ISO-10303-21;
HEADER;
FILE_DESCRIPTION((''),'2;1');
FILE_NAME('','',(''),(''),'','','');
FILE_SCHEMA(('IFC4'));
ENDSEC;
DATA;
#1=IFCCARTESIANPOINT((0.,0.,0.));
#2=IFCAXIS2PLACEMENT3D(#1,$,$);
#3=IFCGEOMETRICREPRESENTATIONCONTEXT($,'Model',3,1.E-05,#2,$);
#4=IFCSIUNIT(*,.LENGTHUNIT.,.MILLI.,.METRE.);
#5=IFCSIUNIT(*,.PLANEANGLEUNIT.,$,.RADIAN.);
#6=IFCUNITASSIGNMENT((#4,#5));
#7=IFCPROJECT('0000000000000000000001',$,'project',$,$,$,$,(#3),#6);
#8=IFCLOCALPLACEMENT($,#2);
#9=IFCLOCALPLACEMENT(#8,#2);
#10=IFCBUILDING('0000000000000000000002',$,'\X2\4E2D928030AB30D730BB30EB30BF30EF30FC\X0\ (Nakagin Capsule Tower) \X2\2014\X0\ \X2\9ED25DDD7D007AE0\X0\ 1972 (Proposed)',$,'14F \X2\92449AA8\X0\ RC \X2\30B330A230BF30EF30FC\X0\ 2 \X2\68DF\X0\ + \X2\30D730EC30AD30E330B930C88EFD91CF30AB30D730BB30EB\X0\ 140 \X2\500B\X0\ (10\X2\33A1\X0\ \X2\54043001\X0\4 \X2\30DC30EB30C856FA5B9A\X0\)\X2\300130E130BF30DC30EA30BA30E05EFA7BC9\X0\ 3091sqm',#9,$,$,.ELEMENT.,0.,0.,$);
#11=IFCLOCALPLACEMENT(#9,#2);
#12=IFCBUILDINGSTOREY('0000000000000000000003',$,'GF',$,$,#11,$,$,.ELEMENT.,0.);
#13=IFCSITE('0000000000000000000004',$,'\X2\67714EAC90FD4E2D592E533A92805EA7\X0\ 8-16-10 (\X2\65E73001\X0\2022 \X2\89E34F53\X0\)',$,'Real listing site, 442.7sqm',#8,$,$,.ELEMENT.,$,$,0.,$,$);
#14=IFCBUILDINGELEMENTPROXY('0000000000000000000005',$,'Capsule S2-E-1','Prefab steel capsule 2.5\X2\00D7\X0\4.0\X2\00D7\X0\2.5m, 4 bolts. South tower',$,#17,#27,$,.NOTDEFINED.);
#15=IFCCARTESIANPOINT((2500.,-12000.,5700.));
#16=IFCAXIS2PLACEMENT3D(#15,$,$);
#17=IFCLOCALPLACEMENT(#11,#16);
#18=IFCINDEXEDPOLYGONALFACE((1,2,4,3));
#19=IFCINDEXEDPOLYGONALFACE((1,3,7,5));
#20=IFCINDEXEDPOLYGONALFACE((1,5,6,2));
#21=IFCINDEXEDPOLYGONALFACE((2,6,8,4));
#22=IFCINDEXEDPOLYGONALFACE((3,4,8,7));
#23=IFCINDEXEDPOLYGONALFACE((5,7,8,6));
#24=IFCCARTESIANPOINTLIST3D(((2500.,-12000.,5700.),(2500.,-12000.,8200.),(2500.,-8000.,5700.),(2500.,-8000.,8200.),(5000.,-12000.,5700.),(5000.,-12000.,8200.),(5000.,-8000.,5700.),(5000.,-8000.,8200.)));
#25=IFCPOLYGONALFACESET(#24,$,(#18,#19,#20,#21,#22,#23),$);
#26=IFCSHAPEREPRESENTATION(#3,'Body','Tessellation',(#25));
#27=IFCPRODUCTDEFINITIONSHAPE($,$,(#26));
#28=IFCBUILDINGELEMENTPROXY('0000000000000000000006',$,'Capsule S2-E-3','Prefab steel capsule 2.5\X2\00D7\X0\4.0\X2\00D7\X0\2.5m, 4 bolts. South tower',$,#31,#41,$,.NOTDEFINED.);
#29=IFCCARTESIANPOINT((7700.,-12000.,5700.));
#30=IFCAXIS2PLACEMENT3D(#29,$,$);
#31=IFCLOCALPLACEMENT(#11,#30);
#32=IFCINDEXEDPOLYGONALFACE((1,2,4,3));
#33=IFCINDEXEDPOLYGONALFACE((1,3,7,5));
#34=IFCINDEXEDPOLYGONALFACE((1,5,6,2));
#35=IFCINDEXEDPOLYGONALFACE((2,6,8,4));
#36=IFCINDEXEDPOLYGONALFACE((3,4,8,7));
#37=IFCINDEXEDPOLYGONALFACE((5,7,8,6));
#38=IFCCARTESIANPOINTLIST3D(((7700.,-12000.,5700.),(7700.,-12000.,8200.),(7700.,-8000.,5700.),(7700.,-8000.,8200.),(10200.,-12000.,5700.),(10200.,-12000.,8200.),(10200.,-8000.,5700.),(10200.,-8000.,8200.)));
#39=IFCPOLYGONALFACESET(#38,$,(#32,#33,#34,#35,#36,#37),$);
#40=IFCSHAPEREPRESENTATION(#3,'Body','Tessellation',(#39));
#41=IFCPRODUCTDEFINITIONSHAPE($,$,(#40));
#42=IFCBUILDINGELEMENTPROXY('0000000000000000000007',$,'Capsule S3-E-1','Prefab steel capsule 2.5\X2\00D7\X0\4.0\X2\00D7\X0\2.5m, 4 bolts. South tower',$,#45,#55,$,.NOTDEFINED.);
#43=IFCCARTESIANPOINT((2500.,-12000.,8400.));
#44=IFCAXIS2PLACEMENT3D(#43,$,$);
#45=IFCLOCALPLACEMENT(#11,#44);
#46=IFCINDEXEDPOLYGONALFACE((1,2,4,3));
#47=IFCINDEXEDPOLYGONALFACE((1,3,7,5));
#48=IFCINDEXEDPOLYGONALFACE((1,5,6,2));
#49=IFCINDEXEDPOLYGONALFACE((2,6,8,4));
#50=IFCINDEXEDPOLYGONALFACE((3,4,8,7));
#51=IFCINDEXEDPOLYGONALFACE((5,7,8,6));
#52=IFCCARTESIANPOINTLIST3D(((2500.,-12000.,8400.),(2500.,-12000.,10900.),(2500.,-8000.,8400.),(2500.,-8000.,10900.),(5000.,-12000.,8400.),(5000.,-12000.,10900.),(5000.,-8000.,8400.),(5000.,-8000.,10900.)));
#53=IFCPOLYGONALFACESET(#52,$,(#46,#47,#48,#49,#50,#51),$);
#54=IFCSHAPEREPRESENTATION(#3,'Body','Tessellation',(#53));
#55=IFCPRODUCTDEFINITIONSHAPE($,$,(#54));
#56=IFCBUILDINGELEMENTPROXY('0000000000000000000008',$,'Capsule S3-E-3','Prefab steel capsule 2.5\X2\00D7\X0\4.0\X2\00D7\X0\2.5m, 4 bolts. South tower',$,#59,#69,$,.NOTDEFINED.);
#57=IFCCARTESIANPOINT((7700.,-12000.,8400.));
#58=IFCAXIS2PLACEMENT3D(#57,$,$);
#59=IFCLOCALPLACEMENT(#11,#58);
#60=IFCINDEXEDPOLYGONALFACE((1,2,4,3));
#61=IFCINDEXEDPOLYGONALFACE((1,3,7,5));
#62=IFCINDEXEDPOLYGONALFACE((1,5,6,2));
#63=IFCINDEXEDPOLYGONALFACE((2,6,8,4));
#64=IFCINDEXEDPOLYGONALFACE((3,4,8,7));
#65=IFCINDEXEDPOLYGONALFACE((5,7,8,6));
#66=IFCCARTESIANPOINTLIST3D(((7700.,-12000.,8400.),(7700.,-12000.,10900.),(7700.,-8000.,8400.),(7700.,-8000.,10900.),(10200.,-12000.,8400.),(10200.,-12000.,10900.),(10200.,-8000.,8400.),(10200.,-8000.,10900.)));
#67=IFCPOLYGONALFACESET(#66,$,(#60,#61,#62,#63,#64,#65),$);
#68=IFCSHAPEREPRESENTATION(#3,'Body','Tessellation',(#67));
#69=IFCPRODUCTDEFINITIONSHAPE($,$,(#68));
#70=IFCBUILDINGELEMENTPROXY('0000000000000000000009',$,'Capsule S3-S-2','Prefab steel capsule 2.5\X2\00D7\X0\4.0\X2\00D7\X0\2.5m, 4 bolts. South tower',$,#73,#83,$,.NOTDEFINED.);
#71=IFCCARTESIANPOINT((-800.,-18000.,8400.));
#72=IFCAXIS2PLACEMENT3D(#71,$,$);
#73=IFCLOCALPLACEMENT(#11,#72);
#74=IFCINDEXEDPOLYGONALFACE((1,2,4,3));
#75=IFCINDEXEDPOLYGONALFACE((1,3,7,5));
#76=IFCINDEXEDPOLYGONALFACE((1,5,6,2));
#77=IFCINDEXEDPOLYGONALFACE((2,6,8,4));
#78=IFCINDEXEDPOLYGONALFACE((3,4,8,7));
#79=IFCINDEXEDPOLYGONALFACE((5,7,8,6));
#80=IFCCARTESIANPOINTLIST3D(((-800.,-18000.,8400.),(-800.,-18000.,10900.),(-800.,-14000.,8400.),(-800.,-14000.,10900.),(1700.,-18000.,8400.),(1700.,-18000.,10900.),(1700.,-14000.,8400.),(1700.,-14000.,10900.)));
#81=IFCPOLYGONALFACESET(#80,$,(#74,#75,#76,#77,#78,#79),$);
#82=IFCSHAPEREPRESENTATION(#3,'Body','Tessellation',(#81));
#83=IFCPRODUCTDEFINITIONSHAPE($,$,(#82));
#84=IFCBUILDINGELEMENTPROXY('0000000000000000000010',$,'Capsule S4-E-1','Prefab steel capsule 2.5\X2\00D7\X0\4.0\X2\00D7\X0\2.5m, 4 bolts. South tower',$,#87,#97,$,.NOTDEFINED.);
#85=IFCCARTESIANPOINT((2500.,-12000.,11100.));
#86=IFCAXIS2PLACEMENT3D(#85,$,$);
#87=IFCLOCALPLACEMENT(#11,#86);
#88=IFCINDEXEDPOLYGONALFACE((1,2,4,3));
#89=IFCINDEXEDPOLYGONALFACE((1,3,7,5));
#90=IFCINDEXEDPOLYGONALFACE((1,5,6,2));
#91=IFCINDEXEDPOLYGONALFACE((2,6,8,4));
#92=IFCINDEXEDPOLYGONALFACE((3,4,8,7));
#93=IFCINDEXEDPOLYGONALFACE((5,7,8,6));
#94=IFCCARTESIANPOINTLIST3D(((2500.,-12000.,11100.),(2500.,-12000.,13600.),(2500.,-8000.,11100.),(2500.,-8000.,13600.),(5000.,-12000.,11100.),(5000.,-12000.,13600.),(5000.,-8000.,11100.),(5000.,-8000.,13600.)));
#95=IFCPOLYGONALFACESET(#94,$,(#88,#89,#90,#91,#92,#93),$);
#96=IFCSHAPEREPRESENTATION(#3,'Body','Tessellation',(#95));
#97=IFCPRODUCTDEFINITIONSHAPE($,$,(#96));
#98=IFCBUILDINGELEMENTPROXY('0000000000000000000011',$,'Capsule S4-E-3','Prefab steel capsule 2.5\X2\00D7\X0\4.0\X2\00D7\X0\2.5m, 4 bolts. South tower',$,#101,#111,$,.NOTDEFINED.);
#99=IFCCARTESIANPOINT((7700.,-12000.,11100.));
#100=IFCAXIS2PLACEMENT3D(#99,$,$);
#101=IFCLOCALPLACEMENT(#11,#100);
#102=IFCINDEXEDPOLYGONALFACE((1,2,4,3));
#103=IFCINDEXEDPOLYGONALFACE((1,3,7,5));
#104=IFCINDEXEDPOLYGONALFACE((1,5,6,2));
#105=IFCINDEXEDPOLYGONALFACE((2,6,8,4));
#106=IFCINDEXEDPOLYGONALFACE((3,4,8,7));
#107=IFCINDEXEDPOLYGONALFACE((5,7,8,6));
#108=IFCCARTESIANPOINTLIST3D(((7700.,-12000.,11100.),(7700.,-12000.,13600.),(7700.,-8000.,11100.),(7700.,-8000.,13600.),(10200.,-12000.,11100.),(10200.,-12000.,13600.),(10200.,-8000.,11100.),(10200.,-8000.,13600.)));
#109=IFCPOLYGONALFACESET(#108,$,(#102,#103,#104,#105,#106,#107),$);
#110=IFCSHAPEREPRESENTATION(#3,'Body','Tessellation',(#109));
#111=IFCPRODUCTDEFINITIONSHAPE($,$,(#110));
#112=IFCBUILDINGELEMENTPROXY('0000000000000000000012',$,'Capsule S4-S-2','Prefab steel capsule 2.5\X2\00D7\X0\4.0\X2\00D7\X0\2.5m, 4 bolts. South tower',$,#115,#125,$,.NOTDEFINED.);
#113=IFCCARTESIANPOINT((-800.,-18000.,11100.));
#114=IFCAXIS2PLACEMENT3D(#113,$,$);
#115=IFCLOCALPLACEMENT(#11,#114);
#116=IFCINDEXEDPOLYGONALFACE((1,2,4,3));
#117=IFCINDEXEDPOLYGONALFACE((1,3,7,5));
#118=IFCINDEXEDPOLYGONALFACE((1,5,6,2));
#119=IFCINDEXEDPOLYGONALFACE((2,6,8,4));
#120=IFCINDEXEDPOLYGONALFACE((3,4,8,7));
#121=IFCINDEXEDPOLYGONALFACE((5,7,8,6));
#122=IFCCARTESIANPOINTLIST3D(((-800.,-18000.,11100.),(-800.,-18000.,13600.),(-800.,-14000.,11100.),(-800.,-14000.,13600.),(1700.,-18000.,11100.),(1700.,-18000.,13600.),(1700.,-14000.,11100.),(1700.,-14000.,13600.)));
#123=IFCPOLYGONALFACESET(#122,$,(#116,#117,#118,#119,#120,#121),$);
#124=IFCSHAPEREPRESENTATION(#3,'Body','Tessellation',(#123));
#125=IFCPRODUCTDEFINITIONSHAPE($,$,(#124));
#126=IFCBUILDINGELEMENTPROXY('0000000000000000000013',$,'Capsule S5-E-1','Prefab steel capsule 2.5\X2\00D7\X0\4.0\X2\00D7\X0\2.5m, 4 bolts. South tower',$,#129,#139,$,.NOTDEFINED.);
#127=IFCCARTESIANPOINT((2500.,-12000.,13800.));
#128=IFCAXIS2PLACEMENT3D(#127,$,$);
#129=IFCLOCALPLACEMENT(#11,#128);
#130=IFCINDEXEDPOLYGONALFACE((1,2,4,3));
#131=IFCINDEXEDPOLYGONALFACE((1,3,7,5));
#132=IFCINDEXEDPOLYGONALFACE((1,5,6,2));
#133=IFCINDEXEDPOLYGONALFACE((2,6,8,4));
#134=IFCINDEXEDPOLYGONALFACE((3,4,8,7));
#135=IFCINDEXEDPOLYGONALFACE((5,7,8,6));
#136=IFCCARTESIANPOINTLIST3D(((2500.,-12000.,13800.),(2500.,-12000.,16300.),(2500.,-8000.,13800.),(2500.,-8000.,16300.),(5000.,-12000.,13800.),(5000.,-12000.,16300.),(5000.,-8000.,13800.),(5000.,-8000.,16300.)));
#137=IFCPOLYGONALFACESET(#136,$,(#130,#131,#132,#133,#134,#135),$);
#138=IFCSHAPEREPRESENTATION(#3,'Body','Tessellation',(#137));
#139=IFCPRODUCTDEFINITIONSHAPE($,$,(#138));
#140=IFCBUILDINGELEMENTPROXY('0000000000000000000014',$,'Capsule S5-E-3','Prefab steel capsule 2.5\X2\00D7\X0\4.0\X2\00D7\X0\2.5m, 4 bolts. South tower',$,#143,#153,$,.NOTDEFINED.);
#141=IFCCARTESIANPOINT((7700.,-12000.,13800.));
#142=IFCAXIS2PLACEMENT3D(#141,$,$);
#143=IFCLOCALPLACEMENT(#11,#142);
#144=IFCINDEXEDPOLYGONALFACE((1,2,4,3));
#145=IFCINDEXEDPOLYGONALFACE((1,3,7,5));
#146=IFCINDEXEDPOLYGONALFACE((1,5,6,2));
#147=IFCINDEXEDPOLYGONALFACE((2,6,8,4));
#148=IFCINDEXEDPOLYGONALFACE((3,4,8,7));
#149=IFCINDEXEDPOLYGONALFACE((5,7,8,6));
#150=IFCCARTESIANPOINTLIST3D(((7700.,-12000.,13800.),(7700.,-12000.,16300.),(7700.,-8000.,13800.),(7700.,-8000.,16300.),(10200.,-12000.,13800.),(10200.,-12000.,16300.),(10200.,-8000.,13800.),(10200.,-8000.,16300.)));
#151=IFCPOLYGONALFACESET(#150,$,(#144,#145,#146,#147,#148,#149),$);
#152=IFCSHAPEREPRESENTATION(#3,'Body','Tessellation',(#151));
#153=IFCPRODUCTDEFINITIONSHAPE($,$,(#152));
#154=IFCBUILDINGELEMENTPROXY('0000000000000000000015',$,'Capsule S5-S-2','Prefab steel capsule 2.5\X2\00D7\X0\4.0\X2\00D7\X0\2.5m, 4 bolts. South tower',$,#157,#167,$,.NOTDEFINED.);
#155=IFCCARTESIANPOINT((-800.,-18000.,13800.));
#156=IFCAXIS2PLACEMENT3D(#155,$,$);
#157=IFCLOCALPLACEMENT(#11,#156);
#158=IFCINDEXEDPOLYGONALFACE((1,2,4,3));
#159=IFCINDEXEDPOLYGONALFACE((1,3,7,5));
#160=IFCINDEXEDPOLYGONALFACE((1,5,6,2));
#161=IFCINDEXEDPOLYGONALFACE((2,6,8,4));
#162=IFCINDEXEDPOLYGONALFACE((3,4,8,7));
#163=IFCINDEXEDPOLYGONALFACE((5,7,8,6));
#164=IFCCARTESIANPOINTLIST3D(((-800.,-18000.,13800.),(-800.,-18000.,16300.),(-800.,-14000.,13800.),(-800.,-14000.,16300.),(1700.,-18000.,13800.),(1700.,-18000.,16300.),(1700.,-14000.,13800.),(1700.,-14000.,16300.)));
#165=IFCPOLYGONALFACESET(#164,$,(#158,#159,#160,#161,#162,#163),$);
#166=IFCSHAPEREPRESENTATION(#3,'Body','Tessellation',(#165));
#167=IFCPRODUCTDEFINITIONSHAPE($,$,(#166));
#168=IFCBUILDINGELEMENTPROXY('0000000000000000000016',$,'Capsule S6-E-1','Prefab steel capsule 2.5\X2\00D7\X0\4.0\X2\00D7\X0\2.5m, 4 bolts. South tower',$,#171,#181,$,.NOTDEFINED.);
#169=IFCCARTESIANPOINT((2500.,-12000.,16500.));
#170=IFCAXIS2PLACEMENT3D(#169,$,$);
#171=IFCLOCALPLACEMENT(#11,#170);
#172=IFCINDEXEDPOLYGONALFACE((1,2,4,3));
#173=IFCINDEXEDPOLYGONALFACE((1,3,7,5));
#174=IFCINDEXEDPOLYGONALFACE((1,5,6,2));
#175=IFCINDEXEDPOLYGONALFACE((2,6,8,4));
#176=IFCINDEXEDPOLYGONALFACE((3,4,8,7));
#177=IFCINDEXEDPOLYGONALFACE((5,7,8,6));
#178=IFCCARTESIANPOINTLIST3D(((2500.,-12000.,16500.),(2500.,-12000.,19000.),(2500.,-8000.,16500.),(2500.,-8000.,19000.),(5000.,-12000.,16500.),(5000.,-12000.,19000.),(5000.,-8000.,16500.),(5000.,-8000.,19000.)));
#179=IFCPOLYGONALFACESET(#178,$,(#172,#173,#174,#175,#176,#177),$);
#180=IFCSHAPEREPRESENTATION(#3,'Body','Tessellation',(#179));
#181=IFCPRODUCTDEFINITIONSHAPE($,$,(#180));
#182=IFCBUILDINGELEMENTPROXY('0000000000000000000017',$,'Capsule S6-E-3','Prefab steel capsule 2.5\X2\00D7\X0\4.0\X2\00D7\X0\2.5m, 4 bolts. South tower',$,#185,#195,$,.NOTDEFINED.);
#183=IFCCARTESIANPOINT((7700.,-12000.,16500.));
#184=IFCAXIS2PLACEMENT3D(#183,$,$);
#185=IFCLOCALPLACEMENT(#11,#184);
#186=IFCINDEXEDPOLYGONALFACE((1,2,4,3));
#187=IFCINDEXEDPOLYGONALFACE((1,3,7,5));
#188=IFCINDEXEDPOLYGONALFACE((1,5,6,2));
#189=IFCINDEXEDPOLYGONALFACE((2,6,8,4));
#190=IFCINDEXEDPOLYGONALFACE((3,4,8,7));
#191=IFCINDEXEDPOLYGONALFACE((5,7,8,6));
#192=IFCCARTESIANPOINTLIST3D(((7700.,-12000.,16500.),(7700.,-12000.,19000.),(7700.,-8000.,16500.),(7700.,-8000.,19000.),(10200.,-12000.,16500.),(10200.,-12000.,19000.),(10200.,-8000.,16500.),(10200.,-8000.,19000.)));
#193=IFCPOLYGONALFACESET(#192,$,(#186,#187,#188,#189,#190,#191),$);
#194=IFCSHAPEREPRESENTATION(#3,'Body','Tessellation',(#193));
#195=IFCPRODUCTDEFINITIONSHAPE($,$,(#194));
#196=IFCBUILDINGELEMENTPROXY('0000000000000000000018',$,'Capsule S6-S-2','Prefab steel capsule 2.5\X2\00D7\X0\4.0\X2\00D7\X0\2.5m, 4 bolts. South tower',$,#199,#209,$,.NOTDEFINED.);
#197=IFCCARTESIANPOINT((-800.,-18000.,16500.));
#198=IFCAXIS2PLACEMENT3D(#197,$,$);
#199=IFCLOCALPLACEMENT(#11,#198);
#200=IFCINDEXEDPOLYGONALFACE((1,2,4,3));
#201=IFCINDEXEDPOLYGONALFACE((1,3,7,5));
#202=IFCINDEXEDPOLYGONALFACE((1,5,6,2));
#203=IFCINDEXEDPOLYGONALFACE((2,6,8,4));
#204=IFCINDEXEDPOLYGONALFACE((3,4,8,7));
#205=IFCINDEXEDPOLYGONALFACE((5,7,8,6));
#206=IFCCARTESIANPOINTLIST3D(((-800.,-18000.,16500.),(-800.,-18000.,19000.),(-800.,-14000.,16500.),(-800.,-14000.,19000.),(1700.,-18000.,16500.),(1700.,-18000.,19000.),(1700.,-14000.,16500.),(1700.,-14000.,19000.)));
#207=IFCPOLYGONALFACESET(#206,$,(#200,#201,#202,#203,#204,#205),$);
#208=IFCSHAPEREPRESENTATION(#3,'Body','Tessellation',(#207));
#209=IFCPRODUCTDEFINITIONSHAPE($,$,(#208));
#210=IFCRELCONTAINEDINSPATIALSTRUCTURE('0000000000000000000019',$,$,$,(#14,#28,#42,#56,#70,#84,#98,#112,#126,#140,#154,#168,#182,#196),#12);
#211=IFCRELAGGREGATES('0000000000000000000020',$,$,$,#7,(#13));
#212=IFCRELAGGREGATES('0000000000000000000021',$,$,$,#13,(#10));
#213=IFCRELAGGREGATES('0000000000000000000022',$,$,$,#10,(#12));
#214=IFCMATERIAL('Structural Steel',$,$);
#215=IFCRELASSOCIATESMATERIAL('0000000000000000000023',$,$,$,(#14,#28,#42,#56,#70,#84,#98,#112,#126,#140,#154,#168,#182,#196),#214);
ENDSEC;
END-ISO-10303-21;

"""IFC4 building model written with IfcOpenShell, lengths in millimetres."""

from ifc_helpers import new_model, si_unit, frame, frame_2d, origin, place, context, project, spatial, rectangle, extrude, material, element, save


model = new_model("IFC4")

# Units and contexts
model_context = context("Model", 3, precision=1e-05, world=origin())
ifc_project = project(units=[si_unit("LENGTHUNIT", "METRE", prefix="MILLI"), si_unit("PLANEANGLEUNIT", "RADIAN")], contexts=[model_context])

# Site, building, storey
site_placement = place(None, origin())
site = spatial("IfcSite", under=ifc_project, at=site_placement, Name="東京都中央区銀座 8-16-10 (旧、2022 解体)", ObjectType="Real listing site, 442.7sqm", CompositionType="ELEMENT", RefElevation=0.0)
building_placement = place(site_placement, origin())
building = spatial("IfcBuilding", under=site, at=building_placement, Name="中銀カプセルタワー (Nakagin Capsule Tower) — 黒川紀章 1972 (Proposed)", ObjectType="14F 鉄骨 RC コアタワー 2 棟 + プレキャスト軽量カプセル 140 個 (10㎡ 各、4 ボルト固定)、メタボリズム建築 3091sqm", CompositionType="ELEMENT", ElevationOfRefHeight=0.0, ElevationOfTerrain=0.0)
storey_placement = place(building_placement, origin())
storey = spatial("IfcBuildingStorey", under=building, at=storey_placement, Name="GF", CompositionType="ELEMENT", Elevation=0.0)

# Shared definitions
ifc_material_1 = material(Name="Structural Steel")

# Building element proxies
proxy_1_placement = place(storey_placement, frame((2500.0, -12000.0, 5700.0)))
element("IfcBuildingElementProxy", 1, at=proxy_1_placement, inside=storey, material=ifc_material_1, Name="Capsule S2-E-1", Description="Prefab steel capsule 2.5×4.0×2.5m, 4 bolts. South tower", PredefinedType="NOTDEFINED", context=model_context, shape_type="SweptSolid", body=[
    extrude(rectangle(XDim=2500.0, YDim=4000.0, at=frame_2d((1250.0, 2000.0))), frame((2500.0, -12000.0, 5700.0)), (0.0, 0.0, 1.0), 2500.0),
])
proxy_2_placement = place(storey_placement, frame((7700.0, -12000.0, 5700.0)))
element("IfcBuildingElementProxy", 2, at=proxy_2_placement, inside=storey, material=ifc_material_1, Name="Capsule S2-E-3", Description="Prefab steel capsule 2.5×4.0×2.5m, 4 bolts. South tower", PredefinedType="NOTDEFINED", context=model_context, shape_type="SweptSolid", body=[
    extrude(rectangle(XDim=2500.0, YDim=4000.0, at=frame_2d((1250.0, 2000.0))), frame((7700.0, -12000.0, 5700.0)), (0.0, 0.0, 1.0), 2500.0),
])
proxy_3_placement = place(storey_placement, frame((2500.0, -12000.0, 8400.0)))
element("IfcBuildingElementProxy", 3, at=proxy_3_placement, inside=storey, material=ifc_material_1, Name="Capsule S3-E-1", Description="Prefab steel capsule 2.5×4.0×2.5m, 4 bolts. South tower", PredefinedType="NOTDEFINED", context=model_context, shape_type="SweptSolid", body=[
    extrude(rectangle(XDim=2500.0, YDim=4000.0, at=frame_2d((1250.0, 2000.0))), frame((2500.0, -12000.0, 8400.0)), (0.0, 0.0, 1.0), 2500.0),
])
proxy_4_placement = place(storey_placement, frame((7700.0, -12000.0, 8400.0)))
element("IfcBuildingElementProxy", 4, at=proxy_4_placement, inside=storey, material=ifc_material_1, Name="Capsule S3-E-3", Description="Prefab steel capsule 2.5×4.0×2.5m, 4 bolts. South tower", PredefinedType="NOTDEFINED", context=model_context, shape_type="SweptSolid", body=[
    extrude(rectangle(XDim=2500.0, YDim=4000.0, at=frame_2d((1250.0, 2000.0))), frame((7700.0, -12000.0, 8400.0)), (0.0, 0.0, 1.0), 2500.0),
])
proxy_5_placement = place(storey_placement, frame((-800.0, -18000.0, 8400.0)))
element("IfcBuildingElementProxy", 5, at=proxy_5_placement, inside=storey, material=ifc_material_1, Name="Capsule S3-S-2", Description="Prefab steel capsule 2.5×4.0×2.5m, 4 bolts. South tower", PredefinedType="NOTDEFINED", context=model_context, shape_type="SweptSolid", body=[
    extrude(rectangle(XDim=2500.0, YDim=4000.0, at=frame_2d((1250.0, 2000.0))), frame((-800.0, -18000.0, 8400.0)), (0.0, 0.0, 1.0), 2500.0),
])
proxy_6_placement = place(storey_placement, frame((2500.0, -12000.0, 11100.0)))
element("IfcBuildingElementProxy", 6, at=proxy_6_placement, inside=storey, material=ifc_material_1, Name="Capsule S4-E-1", Description="Prefab steel capsule 2.5×4.0×2.5m, 4 bolts. South tower", PredefinedType="NOTDEFINED", context=model_context, shape_type="SweptSolid", body=[
    extrude(rectangle(XDim=2500.0, YDim=4000.0, at=frame_2d((1250.0, 2000.0))), frame((2500.0, -12000.0, 11100.0)), (0.0, 0.0, 1.0), 2500.0),
])
proxy_7_placement = place(storey_placement, frame((7700.0, -12000.0, 11100.0)))
element("IfcBuildingElementProxy", 7, at=proxy_7_placement, inside=storey, material=ifc_material_1, Name="Capsule S4-E-3", Description="Prefab steel capsule 2.5×4.0×2.5m, 4 bolts. South tower", PredefinedType="NOTDEFINED", context=model_context, shape_type="SweptSolid", body=[
    extrude(rectangle(XDim=2500.0, YDim=4000.0, at=frame_2d((1250.0, 2000.0))), frame((7700.0, -12000.0, 11100.0)), (0.0, 0.0, 1.0), 2500.0),
])
proxy_8_placement = place(storey_placement, frame((-800.0, -18000.0, 11100.0)))
element("IfcBuildingElementProxy", 8, at=proxy_8_placement, inside=storey, material=ifc_material_1, Name="Capsule S4-S-2", Description="Prefab steel capsule 2.5×4.0×2.5m, 4 bolts. South tower", PredefinedType="NOTDEFINED", context=model_context, shape_type="SweptSolid", body=[
    extrude(rectangle(XDim=2500.0, YDim=4000.0, at=frame_2d((1250.0, 2000.0))), frame((-800.0, -18000.0, 11100.0)), (0.0, 0.0, 1.0), 2500.0),
])
proxy_9_placement = place(storey_placement, frame((2500.0, -12000.0, 13800.0)))
element("IfcBuildingElementProxy", 9, at=proxy_9_placement, inside=storey, material=ifc_material_1, Name="Capsule S5-E-1", Description="Prefab steel capsule 2.5×4.0×2.5m, 4 bolts. South tower", PredefinedType="NOTDEFINED", context=model_context, shape_type="SweptSolid", body=[
    extrude(rectangle(XDim=2500.0, YDim=4000.0, at=frame_2d((1250.0, 2000.0))), frame((2500.0, -12000.0, 13800.0)), (0.0, 0.0, 1.0), 2500.0),
])
proxy_10_placement = place(storey_placement, frame((7700.0, -12000.0, 13800.0)))
element("IfcBuildingElementProxy", 10, at=proxy_10_placement, inside=storey, material=ifc_material_1, Name="Capsule S5-E-3", Description="Prefab steel capsule 2.5×4.0×2.5m, 4 bolts. South tower", PredefinedType="NOTDEFINED", context=model_context, shape_type="SweptSolid", body=[
    extrude(rectangle(XDim=2500.0, YDim=4000.0, at=frame_2d((1250.0, 2000.0))), frame((7700.0, -12000.0, 13800.0)), (0.0, 0.0, 1.0), 2500.0),
])
proxy_11_placement = place(storey_placement, frame((-800.0, -18000.0, 13800.0)))
element("IfcBuildingElementProxy", 11, at=proxy_11_placement, inside=storey, material=ifc_material_1, Name="Capsule S5-S-2", Description="Prefab steel capsule 2.5×4.0×2.5m, 4 bolts. South tower", PredefinedType="NOTDEFINED", context=model_context, shape_type="SweptSolid", body=[
    extrude(rectangle(XDim=2500.0, YDim=4000.0, at=frame_2d((1250.0, 2000.0))), frame((-800.0, -18000.0, 13800.0)), (0.0, 0.0, 1.0), 2500.0),
])
proxy_12_placement = place(storey_placement, frame((2500.0, -12000.0, 16500.0)))
element("IfcBuildingElementProxy", 12, at=proxy_12_placement, inside=storey, material=ifc_material_1, Name="Capsule S6-E-1", Description="Prefab steel capsule 2.5×4.0×2.5m, 4 bolts. South tower", PredefinedType="NOTDEFINED", context=model_context, shape_type="SweptSolid", body=[
    extrude(rectangle(XDim=2500.0, YDim=4000.0, at=frame_2d((1250.0, 2000.0))), frame((2500.0, -12000.0, 16500.0)), (0.0, 0.0, 1.0), 2500.0),
])
proxy_13_placement = place(storey_placement, frame((7700.0, -12000.0, 16500.0)))
element("IfcBuildingElementProxy", 13, at=proxy_13_placement, inside=storey, material=ifc_material_1, Name="Capsule S6-E-3", Description="Prefab steel capsule 2.5×4.0×2.5m, 4 bolts. South tower", PredefinedType="NOTDEFINED", context=model_context, shape_type="SweptSolid", body=[
    extrude(rectangle(XDim=2500.0, YDim=4000.0, at=frame_2d((1250.0, 2000.0))), frame((7700.0, -12000.0, 16500.0)), (0.0, 0.0, 1.0), 2500.0),
])
proxy_14_placement = place(storey_placement, frame((-800.0, -18000.0, 16500.0)))
element("IfcBuildingElementProxy", 14, at=proxy_14_placement, inside=storey, material=ifc_material_1, Name="Capsule S6-S-2", Description="Prefab steel capsule 2.5×4.0×2.5m, 4 bolts. South tower", PredefinedType="NOTDEFINED", context=model_context, shape_type="SweptSolid", body=[
    extrude(rectangle(XDim=2500.0, YDim=4000.0, at=frame_2d((1250.0, 2000.0))), frame((-800.0, -18000.0, 16500.0)), (0.0, 0.0, 1.0), 2500.0),
])

save(model, "model.ifc")
